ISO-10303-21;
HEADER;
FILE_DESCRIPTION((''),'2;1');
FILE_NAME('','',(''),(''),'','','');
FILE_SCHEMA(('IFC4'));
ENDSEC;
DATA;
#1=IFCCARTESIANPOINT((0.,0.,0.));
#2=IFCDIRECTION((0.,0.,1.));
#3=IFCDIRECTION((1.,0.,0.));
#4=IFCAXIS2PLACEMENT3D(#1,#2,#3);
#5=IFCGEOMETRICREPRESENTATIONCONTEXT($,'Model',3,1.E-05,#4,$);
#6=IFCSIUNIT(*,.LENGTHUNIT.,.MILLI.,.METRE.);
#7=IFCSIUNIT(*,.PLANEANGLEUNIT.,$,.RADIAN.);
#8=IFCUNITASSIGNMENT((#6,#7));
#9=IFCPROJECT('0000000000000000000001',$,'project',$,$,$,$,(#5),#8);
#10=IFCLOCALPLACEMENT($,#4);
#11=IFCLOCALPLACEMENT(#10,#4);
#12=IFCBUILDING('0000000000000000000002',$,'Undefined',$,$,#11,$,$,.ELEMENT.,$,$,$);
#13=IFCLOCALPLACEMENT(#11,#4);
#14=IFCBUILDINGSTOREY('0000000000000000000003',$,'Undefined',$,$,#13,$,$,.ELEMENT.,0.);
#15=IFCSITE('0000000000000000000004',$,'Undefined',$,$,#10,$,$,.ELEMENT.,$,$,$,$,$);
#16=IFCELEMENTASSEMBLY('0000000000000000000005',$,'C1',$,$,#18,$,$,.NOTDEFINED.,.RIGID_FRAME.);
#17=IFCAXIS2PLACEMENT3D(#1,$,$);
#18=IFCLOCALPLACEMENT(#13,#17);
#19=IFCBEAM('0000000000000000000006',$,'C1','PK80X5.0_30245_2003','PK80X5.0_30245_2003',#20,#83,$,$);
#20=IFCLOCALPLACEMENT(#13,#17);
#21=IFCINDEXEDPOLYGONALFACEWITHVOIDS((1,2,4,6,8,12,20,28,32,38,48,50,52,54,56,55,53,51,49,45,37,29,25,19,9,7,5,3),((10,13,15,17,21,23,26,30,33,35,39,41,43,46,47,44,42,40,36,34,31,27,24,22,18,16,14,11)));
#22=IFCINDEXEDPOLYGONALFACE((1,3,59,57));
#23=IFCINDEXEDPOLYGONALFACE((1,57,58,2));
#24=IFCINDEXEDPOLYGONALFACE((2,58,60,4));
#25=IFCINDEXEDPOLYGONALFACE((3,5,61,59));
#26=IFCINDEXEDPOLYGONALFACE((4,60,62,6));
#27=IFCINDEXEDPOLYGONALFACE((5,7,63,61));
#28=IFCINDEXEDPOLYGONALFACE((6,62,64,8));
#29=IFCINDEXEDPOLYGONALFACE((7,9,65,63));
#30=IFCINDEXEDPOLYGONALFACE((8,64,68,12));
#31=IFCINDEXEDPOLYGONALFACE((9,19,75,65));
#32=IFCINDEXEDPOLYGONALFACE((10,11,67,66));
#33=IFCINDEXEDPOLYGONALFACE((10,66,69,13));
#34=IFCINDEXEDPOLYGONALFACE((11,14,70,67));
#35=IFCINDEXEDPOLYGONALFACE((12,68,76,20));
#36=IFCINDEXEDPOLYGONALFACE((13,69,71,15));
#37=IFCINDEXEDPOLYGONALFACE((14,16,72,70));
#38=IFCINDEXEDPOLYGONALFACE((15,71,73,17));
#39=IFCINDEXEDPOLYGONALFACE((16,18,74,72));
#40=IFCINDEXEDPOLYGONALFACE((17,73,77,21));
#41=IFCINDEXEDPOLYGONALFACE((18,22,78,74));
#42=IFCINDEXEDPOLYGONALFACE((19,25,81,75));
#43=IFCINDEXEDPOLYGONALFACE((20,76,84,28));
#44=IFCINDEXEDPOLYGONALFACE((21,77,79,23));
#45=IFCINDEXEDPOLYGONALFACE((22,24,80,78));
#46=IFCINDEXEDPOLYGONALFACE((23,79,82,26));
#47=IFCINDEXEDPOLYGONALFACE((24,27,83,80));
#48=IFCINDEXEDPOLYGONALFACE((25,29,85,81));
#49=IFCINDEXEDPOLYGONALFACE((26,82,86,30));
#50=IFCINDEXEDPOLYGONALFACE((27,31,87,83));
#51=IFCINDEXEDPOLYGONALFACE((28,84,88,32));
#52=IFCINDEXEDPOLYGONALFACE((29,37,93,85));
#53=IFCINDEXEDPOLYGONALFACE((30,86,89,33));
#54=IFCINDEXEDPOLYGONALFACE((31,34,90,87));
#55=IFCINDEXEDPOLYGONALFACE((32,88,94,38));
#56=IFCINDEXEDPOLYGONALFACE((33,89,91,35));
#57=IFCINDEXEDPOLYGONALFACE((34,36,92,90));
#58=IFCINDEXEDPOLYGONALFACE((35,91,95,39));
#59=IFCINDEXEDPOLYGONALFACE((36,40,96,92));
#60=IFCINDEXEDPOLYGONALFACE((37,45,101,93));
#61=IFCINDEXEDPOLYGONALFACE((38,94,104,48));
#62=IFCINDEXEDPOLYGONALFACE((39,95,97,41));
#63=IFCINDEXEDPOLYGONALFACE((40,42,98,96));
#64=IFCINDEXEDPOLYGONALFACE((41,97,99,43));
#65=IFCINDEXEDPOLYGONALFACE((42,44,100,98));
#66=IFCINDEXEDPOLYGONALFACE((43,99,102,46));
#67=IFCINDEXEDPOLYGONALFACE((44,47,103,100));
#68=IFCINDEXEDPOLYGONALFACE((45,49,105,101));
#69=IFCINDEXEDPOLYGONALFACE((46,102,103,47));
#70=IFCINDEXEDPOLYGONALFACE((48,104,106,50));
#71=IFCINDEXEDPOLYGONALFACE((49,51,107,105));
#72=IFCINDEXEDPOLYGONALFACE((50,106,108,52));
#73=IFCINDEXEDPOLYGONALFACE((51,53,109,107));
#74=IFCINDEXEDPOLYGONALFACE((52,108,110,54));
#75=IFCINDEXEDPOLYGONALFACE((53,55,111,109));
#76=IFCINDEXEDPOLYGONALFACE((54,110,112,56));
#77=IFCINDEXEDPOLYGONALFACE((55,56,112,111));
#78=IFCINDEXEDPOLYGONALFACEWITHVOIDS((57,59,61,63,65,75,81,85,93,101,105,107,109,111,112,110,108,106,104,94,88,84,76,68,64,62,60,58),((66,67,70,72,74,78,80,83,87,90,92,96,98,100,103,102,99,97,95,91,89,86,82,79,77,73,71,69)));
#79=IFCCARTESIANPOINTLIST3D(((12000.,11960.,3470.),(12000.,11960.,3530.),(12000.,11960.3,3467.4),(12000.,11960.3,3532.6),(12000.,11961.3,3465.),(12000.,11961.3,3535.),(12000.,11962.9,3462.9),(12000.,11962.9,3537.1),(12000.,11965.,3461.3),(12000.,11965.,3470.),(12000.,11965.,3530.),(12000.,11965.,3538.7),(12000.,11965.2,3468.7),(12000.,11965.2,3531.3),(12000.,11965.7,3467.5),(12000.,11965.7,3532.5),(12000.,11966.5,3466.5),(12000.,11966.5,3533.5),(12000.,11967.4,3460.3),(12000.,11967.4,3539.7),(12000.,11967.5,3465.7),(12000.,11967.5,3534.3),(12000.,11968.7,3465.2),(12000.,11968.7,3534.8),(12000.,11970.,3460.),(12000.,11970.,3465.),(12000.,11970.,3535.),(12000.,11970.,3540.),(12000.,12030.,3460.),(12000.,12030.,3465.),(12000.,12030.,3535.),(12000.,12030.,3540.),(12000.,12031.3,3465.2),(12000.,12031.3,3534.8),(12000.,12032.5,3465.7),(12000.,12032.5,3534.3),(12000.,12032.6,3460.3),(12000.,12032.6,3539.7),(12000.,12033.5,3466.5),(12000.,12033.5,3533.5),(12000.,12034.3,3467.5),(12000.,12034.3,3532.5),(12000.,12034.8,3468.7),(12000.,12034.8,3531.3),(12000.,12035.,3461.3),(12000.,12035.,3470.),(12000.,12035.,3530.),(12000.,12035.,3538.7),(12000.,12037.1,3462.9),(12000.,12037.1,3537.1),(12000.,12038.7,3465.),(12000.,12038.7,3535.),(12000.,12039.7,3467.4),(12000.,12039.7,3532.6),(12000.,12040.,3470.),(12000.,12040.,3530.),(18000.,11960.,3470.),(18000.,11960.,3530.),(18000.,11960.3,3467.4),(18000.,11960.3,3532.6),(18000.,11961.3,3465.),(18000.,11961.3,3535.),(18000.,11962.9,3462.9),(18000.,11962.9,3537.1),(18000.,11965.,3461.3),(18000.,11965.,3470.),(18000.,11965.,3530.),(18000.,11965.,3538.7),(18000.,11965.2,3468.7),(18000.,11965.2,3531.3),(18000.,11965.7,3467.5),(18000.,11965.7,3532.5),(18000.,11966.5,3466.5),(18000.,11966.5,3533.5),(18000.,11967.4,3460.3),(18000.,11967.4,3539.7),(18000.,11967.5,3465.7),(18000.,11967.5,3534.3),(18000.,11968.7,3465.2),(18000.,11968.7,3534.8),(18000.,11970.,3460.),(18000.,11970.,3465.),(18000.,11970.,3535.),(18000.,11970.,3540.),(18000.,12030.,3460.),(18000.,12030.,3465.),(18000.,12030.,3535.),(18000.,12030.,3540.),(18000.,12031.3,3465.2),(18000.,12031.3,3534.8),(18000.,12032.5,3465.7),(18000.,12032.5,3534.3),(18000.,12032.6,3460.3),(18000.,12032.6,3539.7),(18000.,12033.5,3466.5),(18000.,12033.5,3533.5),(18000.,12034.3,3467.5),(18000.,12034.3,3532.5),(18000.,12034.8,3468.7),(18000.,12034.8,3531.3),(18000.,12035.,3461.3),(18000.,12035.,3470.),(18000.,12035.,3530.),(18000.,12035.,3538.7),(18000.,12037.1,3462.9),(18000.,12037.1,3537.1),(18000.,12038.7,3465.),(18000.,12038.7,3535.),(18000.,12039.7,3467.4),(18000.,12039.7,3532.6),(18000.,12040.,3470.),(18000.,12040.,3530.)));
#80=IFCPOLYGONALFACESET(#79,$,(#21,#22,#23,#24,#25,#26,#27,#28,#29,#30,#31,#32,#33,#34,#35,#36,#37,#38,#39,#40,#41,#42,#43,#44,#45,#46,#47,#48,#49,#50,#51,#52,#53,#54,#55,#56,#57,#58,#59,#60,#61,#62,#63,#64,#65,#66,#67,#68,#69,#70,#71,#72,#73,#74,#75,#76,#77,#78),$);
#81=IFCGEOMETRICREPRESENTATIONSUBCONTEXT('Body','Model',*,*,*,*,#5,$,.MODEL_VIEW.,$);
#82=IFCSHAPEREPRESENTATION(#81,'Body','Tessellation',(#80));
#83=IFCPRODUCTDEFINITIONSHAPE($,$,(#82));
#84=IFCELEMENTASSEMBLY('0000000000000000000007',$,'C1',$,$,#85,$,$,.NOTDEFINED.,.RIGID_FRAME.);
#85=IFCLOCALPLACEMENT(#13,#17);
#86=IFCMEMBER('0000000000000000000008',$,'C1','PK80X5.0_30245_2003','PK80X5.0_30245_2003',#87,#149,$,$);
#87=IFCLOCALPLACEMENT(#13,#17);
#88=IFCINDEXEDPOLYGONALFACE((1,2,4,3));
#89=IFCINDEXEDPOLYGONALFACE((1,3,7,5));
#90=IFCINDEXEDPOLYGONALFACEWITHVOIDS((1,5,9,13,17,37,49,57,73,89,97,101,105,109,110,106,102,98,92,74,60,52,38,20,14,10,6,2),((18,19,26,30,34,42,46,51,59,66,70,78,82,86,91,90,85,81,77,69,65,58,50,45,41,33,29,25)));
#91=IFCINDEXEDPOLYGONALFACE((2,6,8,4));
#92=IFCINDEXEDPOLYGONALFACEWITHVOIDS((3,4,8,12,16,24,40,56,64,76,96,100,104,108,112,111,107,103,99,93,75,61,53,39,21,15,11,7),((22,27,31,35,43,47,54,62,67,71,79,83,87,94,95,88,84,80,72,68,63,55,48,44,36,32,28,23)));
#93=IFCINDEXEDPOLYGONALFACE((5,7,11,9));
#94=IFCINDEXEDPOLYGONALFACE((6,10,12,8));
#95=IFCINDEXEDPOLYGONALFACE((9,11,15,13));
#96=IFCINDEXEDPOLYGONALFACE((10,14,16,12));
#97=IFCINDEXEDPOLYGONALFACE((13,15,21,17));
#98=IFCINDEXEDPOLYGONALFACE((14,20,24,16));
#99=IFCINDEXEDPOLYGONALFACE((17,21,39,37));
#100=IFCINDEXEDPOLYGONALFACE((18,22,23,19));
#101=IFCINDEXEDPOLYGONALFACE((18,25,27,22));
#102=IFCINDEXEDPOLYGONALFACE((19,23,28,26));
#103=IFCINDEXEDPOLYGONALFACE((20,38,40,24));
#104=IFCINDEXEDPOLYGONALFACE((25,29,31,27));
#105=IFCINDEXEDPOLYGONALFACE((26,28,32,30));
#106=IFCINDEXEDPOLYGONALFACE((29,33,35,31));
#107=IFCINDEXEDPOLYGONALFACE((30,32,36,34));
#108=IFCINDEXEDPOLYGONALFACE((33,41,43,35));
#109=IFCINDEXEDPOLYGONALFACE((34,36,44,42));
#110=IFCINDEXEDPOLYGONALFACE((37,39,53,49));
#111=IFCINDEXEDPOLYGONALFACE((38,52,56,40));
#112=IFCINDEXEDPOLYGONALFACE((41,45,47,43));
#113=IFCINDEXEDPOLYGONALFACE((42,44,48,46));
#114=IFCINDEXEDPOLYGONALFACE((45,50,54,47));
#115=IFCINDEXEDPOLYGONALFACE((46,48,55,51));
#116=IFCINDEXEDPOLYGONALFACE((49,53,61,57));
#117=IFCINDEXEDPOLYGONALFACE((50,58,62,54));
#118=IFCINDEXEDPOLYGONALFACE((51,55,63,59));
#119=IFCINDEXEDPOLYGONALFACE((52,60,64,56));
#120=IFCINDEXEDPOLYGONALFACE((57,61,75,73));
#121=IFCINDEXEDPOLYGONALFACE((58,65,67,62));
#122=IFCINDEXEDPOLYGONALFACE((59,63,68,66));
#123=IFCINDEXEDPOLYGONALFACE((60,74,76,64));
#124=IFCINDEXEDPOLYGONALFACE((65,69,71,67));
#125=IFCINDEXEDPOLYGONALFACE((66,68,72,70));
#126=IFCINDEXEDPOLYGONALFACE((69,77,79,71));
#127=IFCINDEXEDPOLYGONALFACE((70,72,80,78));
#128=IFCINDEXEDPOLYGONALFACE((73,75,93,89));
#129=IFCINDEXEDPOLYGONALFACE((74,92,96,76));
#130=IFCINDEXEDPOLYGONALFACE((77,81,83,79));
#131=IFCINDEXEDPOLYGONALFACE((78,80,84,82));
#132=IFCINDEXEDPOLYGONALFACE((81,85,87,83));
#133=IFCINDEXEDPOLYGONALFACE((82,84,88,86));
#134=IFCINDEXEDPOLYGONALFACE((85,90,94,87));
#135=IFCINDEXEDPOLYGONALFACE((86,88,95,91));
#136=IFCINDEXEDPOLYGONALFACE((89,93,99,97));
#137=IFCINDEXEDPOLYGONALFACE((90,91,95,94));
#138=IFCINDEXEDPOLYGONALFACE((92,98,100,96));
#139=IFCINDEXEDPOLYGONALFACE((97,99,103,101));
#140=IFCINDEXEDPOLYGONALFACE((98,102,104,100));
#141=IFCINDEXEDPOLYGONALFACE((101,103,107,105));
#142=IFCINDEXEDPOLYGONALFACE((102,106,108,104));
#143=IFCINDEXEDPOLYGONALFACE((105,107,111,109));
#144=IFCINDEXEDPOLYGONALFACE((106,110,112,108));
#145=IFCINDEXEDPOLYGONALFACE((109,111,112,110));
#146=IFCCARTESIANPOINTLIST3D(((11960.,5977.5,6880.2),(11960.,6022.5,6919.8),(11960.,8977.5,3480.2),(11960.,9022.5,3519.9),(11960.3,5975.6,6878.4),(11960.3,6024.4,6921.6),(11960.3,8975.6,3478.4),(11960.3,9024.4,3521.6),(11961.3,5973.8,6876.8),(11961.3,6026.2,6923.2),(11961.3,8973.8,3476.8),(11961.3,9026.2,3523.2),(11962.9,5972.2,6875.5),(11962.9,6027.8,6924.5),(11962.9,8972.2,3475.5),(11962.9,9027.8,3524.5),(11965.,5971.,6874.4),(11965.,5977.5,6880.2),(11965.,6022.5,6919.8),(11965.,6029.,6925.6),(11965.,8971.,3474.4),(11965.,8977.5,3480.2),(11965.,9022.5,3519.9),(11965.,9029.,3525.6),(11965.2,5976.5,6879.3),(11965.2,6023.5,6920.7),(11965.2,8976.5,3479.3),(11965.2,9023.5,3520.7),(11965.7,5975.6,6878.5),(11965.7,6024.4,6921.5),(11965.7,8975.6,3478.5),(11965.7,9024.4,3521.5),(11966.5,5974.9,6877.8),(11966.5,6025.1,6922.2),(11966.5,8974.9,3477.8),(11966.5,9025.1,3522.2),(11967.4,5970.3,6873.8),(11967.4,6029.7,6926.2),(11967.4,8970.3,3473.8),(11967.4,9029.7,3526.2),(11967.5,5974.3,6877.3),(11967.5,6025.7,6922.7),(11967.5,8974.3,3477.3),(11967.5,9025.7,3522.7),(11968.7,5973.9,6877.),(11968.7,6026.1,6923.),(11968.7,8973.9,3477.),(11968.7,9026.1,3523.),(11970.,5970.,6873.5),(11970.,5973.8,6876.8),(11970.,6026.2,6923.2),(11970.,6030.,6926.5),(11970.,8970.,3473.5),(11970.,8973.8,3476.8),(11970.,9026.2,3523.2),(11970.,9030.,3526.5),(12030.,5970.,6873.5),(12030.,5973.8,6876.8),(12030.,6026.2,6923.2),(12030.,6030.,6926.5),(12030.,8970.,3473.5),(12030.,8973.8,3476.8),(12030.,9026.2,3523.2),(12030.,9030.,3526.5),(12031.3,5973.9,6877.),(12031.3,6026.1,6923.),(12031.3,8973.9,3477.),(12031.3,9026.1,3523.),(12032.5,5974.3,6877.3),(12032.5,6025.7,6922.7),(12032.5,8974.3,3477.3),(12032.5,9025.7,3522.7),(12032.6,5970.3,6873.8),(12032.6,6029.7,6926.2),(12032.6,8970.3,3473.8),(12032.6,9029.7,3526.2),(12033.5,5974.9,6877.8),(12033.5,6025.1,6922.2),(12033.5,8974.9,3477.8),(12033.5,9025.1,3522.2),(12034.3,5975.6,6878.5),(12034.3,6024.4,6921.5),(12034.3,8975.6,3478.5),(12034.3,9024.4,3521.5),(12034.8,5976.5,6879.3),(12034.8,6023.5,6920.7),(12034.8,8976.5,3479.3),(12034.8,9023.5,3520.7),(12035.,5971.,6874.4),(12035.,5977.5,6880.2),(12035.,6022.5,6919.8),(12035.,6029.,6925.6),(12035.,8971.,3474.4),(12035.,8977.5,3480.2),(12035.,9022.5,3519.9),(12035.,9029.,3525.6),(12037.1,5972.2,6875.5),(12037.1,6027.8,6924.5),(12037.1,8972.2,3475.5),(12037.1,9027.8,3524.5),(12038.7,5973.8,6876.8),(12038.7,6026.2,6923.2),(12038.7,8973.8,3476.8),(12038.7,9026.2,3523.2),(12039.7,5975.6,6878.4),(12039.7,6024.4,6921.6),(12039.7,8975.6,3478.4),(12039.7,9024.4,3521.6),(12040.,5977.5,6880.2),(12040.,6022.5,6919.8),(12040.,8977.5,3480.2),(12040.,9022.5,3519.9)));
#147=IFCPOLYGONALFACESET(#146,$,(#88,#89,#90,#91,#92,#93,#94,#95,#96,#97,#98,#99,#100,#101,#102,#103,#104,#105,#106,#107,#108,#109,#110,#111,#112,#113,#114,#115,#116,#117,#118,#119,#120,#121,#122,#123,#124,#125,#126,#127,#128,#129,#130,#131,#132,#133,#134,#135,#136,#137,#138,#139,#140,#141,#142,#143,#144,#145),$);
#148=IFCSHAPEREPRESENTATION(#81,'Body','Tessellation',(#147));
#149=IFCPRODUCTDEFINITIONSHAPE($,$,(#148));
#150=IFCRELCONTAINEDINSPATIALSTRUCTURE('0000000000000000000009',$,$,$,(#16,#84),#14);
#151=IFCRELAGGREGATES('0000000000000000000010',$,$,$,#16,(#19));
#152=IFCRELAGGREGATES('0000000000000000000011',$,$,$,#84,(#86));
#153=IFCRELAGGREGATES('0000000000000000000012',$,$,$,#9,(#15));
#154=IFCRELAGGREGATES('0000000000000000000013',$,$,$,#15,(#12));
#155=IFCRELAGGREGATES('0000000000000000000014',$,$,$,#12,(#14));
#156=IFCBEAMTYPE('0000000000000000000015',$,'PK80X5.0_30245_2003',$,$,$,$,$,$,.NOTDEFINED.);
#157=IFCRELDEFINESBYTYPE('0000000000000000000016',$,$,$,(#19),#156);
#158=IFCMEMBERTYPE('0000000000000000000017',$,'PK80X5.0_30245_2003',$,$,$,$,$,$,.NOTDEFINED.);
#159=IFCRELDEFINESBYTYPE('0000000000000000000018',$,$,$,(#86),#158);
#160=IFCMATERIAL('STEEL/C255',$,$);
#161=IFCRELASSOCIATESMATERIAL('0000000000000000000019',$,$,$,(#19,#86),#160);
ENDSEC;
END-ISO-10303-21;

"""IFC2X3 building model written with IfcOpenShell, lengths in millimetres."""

from ifc_helpers import new_model, si_unit, frame, origin_with_axes, origin_2d_with_axis, place, context, subcontext, project, spatial, hollow_rectangle, extrude, material, type_object, element, aggregate, save


model = new_model("IFC2X3")

# Units and contexts
model_context = context("Model", 3, precision=1e-05, world=origin_with_axes())
body_context = subcontext(model_context, "Body", "Model", "MODEL_VIEW")
ifc_project = project(units=[si_unit("LENGTHUNIT", "METRE", prefix="MILLI"), si_unit("PLANEANGLEUNIT", "RADIAN")], contexts=[model_context])

# Site, building, storey
site_placement = place(None, origin_with_axes())
site = spatial("IfcSite", under=ifc_project, at=site_placement, Name="Undefined", CompositionType="ELEMENT")
building_placement = place(site_placement, origin_with_axes())
building = spatial("IfcBuilding", under=site, at=building_placement, Name="Undefined", CompositionType="ELEMENT")
storey_placement = place(building_placement, origin_with_axes())
storey = spatial("IfcBuildingStorey", under=building, at=storey_placement, Name="Undefined", CompositionType="ELEMENT", Elevation=0.0)

# Element assembly, beam
ifc_material_1 = material(Name="STEEL/C255")
beam_type_1 = type_object("IfcBeamType", Name="PK80X5.0_30245_2003", PredefinedType="NOTDEFINED")
assembly_1_placement = place(storey_placement, origin_with_axes())
assembly_1 = element("IfcElementAssembly", 1, at=assembly_1_placement, inside=storey, Name="C1", AssemblyPlace="NOTDEFINED", PredefinedType="RIGID_FRAME")
beam_1_placement = place(assembly_1_placement, frame((12000.0, 12000.0, 3500.0), z_axis=(0.0, 0.0, -1.0), x_axis=(1.0, 0.0, 0.0)))
beam_1 = element("IfcBeam", 2, at=beam_1_placement, type_object=beam_type_1, material=ifc_material_1, Name="C1", Description="PK80X5.0_30245_2003", ObjectType="PK80X5.0_30245_2003", context=body_context, shape_type="SweptSolid", body=[
    extrude(hollow_rectangle(XDim=80.0, YDim=80.0, WallThickness=5.0, InnerFilletRadius=5.0, OuterFilletRadius=10.0, at=origin_2d_with_axis()), frame((6000.0, 0.0, 0.0), z_axis=(-1.0, 0.0, 0.0), x_axis=(0.0, -1.0, 0.0)), (0.0, 0.0, 1.0), 6000.0),
])
aggregate(assembly_1, [beam_1])

# Element assembly, member
assembly_2_placement = place(storey_placement, origin_with_axes())
assembly_2 = element("IfcElementAssembly", 3, at=assembly_2_placement, inside=storey, Name="C1", AssemblyPlace="NOTDEFINED", PredefinedType="RIGID_FRAME")
member_type = type_object("IfcMemberType", Name="PK80X5.0_30245_2003", PredefinedType="NOTDEFINED")
member_1_placement = place(assembly_2_placement, frame((12000.0, 9000.0, 3500.0), z_axis=(0.0, -0.749838, -0.661622), x_axis=(0.0, -0.661622, 0.749838)))
member_1 = element("IfcMember", 4, at=member_1_placement, type_object=member_type, material=ifc_material_1, Name="C1", Description="PK80X5.0_30245_2003", ObjectType="PK80X5.0_30245_2003", context=body_context, shape_type="SweptSolid", body=[
    extrude(hollow_rectangle(XDim=80.0, YDim=80.0, WallThickness=5.0, InnerFilletRadius=5.0, OuterFilletRadius=10.0, at=origin_2d_with_axis()), frame((4534.3, 0.0, 0.0), z_axis=(-1.0, 0.0, 0.0), x_axis=(0.0, -1.0, 0.0)), (0.0, 0.0, 1.0), 4534.3),
])
aggregate(assembly_2, [member_1])

save(model, "model.ifc")
